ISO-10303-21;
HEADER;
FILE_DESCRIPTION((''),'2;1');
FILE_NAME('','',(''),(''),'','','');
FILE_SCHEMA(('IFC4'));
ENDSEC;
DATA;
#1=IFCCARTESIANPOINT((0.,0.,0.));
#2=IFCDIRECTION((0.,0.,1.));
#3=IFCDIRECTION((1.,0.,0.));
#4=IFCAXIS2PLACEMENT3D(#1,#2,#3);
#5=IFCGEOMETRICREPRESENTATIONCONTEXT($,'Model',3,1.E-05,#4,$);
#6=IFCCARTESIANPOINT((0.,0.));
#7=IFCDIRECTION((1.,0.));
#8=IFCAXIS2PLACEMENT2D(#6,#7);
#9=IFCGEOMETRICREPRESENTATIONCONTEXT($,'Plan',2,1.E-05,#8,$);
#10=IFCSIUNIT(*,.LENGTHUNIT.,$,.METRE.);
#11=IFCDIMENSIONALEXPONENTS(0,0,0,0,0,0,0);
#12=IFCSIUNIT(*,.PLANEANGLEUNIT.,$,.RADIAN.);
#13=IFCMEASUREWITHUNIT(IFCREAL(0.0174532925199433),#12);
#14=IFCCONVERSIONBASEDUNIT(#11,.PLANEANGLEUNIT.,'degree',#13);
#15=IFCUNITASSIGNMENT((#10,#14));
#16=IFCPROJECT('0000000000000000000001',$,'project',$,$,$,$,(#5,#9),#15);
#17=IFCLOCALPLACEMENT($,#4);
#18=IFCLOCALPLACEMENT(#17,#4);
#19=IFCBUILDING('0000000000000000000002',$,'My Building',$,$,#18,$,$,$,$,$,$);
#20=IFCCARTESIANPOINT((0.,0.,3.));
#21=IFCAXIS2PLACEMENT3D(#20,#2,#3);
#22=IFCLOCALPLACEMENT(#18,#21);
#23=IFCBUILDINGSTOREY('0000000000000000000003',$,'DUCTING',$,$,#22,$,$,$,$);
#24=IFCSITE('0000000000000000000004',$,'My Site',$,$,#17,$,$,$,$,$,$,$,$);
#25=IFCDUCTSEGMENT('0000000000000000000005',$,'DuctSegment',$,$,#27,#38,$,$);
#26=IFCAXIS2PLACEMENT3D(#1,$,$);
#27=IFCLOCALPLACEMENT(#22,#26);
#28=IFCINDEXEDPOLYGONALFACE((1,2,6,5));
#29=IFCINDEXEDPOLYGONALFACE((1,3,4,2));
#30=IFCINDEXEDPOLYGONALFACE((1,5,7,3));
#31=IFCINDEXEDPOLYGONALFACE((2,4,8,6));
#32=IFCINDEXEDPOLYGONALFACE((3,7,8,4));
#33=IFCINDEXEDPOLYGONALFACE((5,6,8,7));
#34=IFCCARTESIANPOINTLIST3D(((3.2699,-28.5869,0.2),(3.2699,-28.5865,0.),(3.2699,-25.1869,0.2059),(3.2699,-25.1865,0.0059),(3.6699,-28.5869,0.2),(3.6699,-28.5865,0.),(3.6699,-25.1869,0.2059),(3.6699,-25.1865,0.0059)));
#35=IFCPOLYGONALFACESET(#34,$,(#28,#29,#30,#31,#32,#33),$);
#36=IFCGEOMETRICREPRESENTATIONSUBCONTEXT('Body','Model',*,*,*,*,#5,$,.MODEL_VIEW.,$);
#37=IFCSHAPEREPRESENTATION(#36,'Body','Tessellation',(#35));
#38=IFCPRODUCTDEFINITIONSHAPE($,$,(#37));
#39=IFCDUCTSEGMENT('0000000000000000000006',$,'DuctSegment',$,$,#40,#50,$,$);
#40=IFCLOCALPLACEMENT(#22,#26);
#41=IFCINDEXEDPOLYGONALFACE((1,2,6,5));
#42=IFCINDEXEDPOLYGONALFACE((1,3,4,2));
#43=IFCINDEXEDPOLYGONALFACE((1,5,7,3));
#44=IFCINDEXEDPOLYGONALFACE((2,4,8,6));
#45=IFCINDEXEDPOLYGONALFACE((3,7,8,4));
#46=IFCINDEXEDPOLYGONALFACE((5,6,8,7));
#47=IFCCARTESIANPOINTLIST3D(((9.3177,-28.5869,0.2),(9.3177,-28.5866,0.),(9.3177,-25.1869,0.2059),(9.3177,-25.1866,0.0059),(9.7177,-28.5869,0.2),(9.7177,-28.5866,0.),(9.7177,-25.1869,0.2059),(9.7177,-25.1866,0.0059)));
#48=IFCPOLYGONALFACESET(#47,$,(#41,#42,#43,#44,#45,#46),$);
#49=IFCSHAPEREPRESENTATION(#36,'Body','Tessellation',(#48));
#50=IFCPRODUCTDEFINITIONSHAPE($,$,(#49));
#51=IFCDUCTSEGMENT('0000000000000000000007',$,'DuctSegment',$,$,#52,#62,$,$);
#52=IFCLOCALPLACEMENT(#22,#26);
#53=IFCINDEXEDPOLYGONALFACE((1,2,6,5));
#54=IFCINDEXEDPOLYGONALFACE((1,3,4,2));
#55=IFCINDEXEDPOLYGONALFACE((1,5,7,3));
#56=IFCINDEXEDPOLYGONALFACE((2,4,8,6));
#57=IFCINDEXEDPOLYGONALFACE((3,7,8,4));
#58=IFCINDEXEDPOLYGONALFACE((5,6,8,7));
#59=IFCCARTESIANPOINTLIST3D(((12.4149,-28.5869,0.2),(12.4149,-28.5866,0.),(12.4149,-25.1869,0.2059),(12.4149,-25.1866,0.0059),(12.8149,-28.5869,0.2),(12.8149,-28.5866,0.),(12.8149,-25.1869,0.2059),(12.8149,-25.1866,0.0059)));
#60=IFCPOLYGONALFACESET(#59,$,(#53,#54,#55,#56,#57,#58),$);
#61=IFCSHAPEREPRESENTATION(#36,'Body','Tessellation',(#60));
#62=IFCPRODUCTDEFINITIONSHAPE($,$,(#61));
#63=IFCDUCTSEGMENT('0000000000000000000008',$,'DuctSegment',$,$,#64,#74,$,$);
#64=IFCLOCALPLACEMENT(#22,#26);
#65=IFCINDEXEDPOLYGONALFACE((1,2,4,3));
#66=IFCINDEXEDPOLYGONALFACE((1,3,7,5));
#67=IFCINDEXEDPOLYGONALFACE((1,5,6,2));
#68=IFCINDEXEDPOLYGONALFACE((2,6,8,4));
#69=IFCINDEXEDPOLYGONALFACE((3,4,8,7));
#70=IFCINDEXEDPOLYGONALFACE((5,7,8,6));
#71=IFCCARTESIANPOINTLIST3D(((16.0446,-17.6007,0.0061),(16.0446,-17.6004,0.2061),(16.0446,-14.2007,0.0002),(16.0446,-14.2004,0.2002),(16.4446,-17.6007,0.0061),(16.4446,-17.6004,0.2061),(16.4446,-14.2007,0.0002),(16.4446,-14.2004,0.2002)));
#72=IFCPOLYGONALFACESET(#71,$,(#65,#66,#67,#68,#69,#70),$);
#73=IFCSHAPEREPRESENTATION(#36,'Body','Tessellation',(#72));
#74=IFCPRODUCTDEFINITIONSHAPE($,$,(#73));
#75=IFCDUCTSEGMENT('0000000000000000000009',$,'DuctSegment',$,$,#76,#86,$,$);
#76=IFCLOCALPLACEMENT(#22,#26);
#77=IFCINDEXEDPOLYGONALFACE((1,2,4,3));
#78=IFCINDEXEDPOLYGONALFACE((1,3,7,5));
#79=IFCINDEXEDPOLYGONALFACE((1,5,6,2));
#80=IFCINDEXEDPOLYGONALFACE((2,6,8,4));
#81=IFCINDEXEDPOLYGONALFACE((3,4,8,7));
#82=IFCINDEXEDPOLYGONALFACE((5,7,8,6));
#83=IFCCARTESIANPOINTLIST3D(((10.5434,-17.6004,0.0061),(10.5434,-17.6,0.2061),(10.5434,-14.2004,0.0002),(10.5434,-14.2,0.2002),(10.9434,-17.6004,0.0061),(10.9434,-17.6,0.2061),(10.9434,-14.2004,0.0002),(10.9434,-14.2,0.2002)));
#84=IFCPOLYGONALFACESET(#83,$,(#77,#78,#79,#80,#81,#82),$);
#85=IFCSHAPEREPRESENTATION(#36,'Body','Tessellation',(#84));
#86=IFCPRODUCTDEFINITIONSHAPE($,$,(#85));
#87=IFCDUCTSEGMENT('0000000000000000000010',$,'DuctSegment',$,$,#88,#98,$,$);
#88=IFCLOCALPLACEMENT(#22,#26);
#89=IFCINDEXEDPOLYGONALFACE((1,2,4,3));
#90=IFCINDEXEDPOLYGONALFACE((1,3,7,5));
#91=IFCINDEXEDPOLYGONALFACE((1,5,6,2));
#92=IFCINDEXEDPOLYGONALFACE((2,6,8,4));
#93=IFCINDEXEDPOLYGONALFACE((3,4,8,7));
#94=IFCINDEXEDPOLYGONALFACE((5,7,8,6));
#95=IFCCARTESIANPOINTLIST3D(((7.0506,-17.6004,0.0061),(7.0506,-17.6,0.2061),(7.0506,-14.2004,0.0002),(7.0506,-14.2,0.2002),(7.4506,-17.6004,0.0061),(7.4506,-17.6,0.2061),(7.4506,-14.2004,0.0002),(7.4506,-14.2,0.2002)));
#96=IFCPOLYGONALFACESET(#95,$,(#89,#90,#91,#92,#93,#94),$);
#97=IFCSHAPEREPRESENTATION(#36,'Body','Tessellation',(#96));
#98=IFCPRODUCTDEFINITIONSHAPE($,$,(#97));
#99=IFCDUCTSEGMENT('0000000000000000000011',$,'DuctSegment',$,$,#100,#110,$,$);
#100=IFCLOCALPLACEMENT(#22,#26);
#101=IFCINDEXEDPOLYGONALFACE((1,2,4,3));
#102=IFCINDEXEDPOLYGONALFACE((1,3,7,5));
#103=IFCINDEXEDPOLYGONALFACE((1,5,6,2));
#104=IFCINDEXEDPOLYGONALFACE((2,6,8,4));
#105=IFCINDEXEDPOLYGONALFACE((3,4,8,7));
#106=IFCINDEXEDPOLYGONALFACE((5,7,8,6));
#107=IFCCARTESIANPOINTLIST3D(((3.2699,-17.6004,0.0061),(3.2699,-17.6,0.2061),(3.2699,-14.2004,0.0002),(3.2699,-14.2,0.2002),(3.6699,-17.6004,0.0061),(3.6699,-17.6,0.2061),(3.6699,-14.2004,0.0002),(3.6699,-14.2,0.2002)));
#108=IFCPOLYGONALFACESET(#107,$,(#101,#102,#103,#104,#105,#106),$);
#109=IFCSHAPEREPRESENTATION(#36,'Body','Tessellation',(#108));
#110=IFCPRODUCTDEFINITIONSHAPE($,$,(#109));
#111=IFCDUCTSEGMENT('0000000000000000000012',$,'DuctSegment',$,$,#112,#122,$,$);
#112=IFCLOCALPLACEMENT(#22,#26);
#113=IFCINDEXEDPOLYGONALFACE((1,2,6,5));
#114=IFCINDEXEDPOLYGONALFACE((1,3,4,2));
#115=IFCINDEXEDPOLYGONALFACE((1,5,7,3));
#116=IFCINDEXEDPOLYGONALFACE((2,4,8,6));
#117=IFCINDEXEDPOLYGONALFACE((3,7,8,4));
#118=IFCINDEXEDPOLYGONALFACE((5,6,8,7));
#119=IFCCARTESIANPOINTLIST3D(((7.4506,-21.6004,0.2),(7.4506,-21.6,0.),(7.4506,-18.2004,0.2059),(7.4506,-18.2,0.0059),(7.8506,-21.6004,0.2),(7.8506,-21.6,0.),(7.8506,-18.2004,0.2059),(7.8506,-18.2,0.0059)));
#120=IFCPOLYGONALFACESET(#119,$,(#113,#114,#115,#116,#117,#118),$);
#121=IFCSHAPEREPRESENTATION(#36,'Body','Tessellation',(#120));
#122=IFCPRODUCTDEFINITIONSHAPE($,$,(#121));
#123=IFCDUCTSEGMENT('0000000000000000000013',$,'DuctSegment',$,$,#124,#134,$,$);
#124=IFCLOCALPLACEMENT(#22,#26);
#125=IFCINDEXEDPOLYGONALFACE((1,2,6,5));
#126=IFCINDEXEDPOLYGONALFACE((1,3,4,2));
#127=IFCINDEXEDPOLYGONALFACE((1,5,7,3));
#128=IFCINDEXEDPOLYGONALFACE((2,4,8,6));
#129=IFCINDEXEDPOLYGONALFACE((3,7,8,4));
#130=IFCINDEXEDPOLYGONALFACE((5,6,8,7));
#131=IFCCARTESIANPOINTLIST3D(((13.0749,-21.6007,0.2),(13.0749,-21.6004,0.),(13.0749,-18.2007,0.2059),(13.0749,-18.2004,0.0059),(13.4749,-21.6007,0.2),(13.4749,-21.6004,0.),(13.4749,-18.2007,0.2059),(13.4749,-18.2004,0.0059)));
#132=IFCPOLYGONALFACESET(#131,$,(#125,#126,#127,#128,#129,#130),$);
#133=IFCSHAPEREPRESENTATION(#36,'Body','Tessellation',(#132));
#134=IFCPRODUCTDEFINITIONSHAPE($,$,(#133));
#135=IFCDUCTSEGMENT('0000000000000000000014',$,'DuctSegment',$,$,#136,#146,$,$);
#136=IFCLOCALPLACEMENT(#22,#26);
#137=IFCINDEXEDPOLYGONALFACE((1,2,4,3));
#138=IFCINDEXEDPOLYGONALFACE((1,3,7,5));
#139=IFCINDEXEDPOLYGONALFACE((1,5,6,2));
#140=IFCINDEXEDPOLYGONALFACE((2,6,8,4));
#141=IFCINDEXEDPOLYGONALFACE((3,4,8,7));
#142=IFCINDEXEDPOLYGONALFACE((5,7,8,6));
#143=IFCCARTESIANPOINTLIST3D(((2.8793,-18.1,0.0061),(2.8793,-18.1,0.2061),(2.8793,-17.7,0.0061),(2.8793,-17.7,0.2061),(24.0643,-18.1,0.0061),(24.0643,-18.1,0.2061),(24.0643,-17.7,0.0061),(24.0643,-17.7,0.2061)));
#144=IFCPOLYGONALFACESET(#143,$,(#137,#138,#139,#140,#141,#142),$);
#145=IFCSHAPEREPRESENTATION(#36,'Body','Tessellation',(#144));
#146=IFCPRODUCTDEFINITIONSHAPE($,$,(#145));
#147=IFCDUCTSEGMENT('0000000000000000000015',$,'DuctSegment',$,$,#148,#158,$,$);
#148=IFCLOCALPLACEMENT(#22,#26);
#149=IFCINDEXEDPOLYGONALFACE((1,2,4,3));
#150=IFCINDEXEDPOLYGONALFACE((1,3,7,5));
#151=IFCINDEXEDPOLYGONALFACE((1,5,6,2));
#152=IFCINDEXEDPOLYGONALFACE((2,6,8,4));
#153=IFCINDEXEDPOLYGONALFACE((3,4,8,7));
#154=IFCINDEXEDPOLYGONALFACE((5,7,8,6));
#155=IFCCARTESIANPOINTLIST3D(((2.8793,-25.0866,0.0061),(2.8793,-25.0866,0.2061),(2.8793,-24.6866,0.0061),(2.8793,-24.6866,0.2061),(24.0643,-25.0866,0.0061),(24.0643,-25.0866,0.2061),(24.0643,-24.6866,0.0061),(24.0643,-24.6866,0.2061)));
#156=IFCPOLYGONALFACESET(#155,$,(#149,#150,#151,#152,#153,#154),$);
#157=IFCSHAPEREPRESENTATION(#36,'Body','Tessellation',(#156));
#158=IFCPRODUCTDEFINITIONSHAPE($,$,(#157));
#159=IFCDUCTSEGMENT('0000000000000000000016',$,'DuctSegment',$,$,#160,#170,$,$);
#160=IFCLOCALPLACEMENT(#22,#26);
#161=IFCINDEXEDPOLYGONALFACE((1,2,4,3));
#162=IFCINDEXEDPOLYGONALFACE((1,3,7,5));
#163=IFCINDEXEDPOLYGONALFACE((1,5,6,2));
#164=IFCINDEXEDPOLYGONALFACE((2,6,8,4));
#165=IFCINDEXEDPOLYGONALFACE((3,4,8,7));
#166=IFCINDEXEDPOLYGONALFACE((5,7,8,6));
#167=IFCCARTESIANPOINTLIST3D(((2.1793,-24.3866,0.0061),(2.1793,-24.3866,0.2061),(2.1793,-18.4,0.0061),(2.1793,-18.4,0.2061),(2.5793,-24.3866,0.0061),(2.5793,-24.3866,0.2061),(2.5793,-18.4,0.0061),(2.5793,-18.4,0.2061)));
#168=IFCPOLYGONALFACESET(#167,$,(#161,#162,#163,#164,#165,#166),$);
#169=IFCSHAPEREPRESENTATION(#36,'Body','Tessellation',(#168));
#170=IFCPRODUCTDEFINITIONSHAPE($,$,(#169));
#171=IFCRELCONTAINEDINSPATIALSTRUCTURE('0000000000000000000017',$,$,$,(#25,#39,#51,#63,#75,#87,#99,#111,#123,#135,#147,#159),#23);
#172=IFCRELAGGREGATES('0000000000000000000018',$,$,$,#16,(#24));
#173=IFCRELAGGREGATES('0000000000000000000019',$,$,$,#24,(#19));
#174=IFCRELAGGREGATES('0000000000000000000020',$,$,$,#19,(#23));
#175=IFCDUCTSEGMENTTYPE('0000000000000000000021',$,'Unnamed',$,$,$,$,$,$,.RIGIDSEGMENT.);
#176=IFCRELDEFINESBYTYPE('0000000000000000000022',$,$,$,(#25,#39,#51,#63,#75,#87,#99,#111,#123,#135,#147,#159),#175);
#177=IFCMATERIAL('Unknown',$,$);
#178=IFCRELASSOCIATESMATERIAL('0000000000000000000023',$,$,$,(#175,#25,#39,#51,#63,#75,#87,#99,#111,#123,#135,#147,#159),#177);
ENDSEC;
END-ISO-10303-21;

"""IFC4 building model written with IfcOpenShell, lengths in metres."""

from ifc_helpers import new_model, entity, si_unit, converted_unit, frame, origin_with_axes, origin_2d_with_axis, place, context, subcontext, project, spatial, rectangle, extrude, material, material_profile, profile_set, profile_usage, type_object, element, save


model = new_model("IFC4")

# Units and contexts
model_context = context("Model", 3, precision=1e-05, world=origin_with_axes())
plan_context = context("Plan", 2, precision=1e-05, world=origin_2d_with_axis())
body_context = subcontext(model_context, "Body", "Model", "MODEL_VIEW")
ifc_project = project(units=[si_unit("LENGTHUNIT", "METRE"), converted_unit("PLANEANGLEUNIT", "degree", entity("IfcReal", 0.0174532925199433), si_unit("PLANEANGLEUNIT", "RADIAN"), dimensions=[0, 0, 0, 0, 0, 0, 0])], contexts=[model_context, plan_context])

# Site, building, storey
site_placement = place(None, origin_with_axes())
site = spatial("IfcSite", under=ifc_project, at=site_placement, Name="My Site")
building_placement = place(site_placement, origin_with_axes())
building = spatial("IfcBuilding", under=site, at=building_placement, Name="My Building")
storey_placement = place(building_placement, frame((0.0, 0.0, 3.0), z_axis=(0.0, 0.0, 1.0), x_axis=(1.0, 0.0, 0.0)))
storey = spatial("IfcBuildingStorey", under=building, at=storey_placement, Name="DUCTING")

# Duct segments
ifc_material = material(Name="Unknown")
ifc_material_profile_1 = material_profile(ifc_material, rectangle(XDim=0.4, YDim=0.2))
ifc_profile_set_1 = profile_set([ifc_material_profile_1])
ifc_profile_usage_1 = profile_usage(ifc_profile_set_1, cardinal=5)
duct_segment_type = type_object("IfcDuctSegmentType", Name="Unnamed", PredefinedType="RIGIDSEGMENT", material=ifc_profile_set_1)
duct_segment_1_placement = place(storey_placement, frame((3.4699, -25.1867, 0.1059), z_axis=(0.0, -0.999998, -0.001745), x_axis=(1.0, 0.0, 0.0)))
element("IfcDuctSegment", 1, at=duct_segment_1_placement, inside=storey, type_object=duct_segment_type, material=ifc_profile_usage_1, Name="DuctSegment", context=body_context, shape_type="SweptSolid", body=[
    extrude(rectangle(XDim=0.4, YDim=0.2), origin_with_axes(), (0.0, 0.0, 1.0), 3.4),
])
ifc_profile_usage_2 = profile_usage(ifc_profile_set_1, cardinal=5)
duct_segment_2_placement = place(storey_placement, frame((9.5177, -25.1867, 0.1059), z_axis=(0.0, -0.999998, -0.001745), x_axis=(1.0, 0.0, 0.0)))
element("IfcDuctSegment", 2, at=duct_segment_2_placement, inside=storey, type_object=duct_segment_type, material=ifc_profile_usage_2, Name="DuctSegment", context=body_context, shape_type="SweptSolid", body=[
    extrude(rectangle(XDim=0.4, YDim=0.2), origin_with_axes(), (0.0, 0.0, 1.0), 3.4),
])
ifc_profile_usage_3 = profile_usage(ifc_profile_set_1, cardinal=5)
duct_segment_3_placement = place(storey_placement, frame((12.6149, -25.1867, 0.1059), z_axis=(0.0, -0.999998, -0.001745), x_axis=(1.0, 0.0, 0.0)))
element("IfcDuctSegment", 3, at=duct_segment_3_placement, inside=storey, type_object=duct_segment_type, material=ifc_profile_usage_3, Name="DuctSegment", context=body_context, shape_type="SweptSolid", body=[
    extrude(rectangle(XDim=0.4, YDim=0.2), origin_with_axes(), (0.0, 0.0, 1.0), 3.4),
])
ifc_profile_usage_4 = profile_usage(ifc_profile_set_1, cardinal=5)
duct_segment_4_placement = place(storey_placement, frame((16.2446, -17.6006, 0.1061), z_axis=(0.0, 0.999998, -0.001745), x_axis=(-1.0, 0.0, 0.0)))
element("IfcDuctSegment", 4, at=duct_segment_4_placement, inside=storey, type_object=duct_segment_type, material=ifc_profile_usage_4, Name="DuctSegment", context=body_context, shape_type="SweptSolid", body=[
    extrude(rectangle(XDim=0.4, YDim=0.2), origin_with_axes(), (0.0, 0.0, 1.0), 3.4),
])
ifc_profile_usage_5 = profile_usage(ifc_profile_set_1, cardinal=5)
duct_segment_5_placement = place(storey_placement, frame((10.7434, -17.6002, 0.1061), z_axis=(0.0, 0.999998, -0.001745), x_axis=(-1.0, 0.0, 0.0)))
element("IfcDuctSegment", 5, at=duct_segment_5_placement, inside=storey, type_object=duct_segment_type, material=ifc_profile_usage_5, Name="DuctSegment", context=body_context, shape_type="SweptSolid", body=[
    extrude(rectangle(XDim=0.4, YDim=0.2), origin_with_axes(), (0.0, 0.0, 1.0), 3.4),
])
ifc_profile_usage_6 = profile_usage(ifc_profile_set_1, cardinal=5)
duct_segment_6_placement = place(storey_placement, frame((7.2506, -17.6002, 0.1061), z_axis=(0.0, 0.999998, -0.001745), x_axis=(-1.0, 0.0, 0.0)))
element("IfcDuctSegment", 6, at=duct_segment_6_placement, inside=storey, type_object=duct_segment_type, material=ifc_profile_usage_6, Name="DuctSegment", context=body_context, shape_type="SweptSolid", body=[
    extrude(rectangle(XDim=0.4, YDim=0.2), origin_with_axes(), (0.0, 0.0, 1.0), 3.4),
])
ifc_profile_usage_7 = profile_usage(ifc_profile_set_1, cardinal=5)
duct_segment_7_placement = place(storey_placement, frame((3.4699, -17.6002, 0.1061), z_axis=(0.0, 0.999998, -0.001745), x_axis=(-1.0, 0.0, 0.0)))
element("IfcDuctSegment", 7, at=duct_segment_7_placement, inside=storey, type_object=duct_segment_type, material=ifc_profile_usage_7, Name="DuctSegment", context=body_context, shape_type="SweptSolid", body=[
    extrude(rectangle(XDim=0.4, YDim=0.2), origin_with_axes(), (0.0, 0.0, 1.0), 3.4),
])
ifc_profile_usage_8 = profile_usage(ifc_profile_set_1, cardinal=5)
duct_segment_8_placement = place(storey_placement, frame((7.6506, -18.2002, 0.1059), z_axis=(0.0, -0.999998, -0.001745), x_axis=(1.0, 0.0, 0.0)))
element("IfcDuctSegment", 8, at=duct_segment_8_placement, inside=storey, type_object=duct_segment_type, material=ifc_profile_usage_8, Name="DuctSegment", context=body_context, shape_type="SweptSolid", body=[
    extrude(rectangle(XDim=0.4, YDim=0.2), origin_with_axes(), (0.0, 0.0, 1.0), 3.4),
])
ifc_profile_usage_9 = profile_usage(ifc_profile_set_1, cardinal=5)
duct_segment_9_placement = place(storey_placement, frame((13.2749, -18.2006, 0.1059), z_axis=(0.0, -0.999998, -0.001745), x_axis=(1.0, 0.0, 0.0)))
element("IfcDuctSegment", 9, at=duct_segment_9_placement, inside=storey, type_object=duct_segment_type, material=ifc_profile_usage_9, Name="DuctSegment", context=body_context, shape_type="SweptSolid", body=[
    extrude(rectangle(XDim=0.4, YDim=0.2), origin_with_axes(), (0.0, 0.0, 1.0), 3.4),
])
ifc_profile_usage_10 = profile_usage(ifc_profile_set_1, cardinal=5)
duct_segment_10_placement = place(storey_placement, frame((2.8793, -17.9, 0.1061), z_axis=(1.0, 0.0, 0.0), x_axis=(0.0, 1.0, 0.0)))
element("IfcDuctSegment", 10, at=duct_segment_10_placement, inside=storey, type_object=duct_segment_type, material=ifc_profile_usage_10, Name="DuctSegment", context=body_context, shape_type="SweptSolid", body=[
    extrude(rectangle(XDim=0.4, YDim=0.2), origin_with_axes(), (0.0, 0.0, 1.0), 21.185),
])
ifc_profile_usage_11 = profile_usage(ifc_profile_set_1, cardinal=5)
duct_segment_11_placement = place(storey_placement, frame((2.8793, -24.8866, 0.1061), z_axis=(1.0, 0.0, 0.0), x_axis=(0.0, 1.0, 0.0)))
element("IfcDuctSegment", 11, at=duct_segment_11_placement, inside=storey, type_object=duct_segment_type, material=ifc_profile_usage_11, Name="DuctSegment", context=body_context, shape_type="SweptSolid", body=[
    extrude(rectangle(XDim=0.4, YDim=0.2), origin_with_axes(), (0.0, 0.0, 1.0), 21.185),
])
ifc_profile_usage_12 = profile_usage(ifc_profile_set_1, cardinal=5)
duct_segment_12_placement = place(storey_placement, frame((2.3793, -18.4, 0.1061), z_axis=(0.0, -1.0, 0.0), x_axis=(1.0, 0.0, 0.0)))
element("IfcDuctSegment", 12, at=duct_segment_12_placement, inside=storey, type_object=duct_segment_type, material=ifc_profile_usage_12, Name="DuctSegment", context=body_context, shape_type="SweptSolid", body=[
    extrude(rectangle(XDim=0.4, YDim=0.2), origin_with_axes(), (0.0, 0.0, 1.0), 5.9866),
])

save(model, "model.ifc")
